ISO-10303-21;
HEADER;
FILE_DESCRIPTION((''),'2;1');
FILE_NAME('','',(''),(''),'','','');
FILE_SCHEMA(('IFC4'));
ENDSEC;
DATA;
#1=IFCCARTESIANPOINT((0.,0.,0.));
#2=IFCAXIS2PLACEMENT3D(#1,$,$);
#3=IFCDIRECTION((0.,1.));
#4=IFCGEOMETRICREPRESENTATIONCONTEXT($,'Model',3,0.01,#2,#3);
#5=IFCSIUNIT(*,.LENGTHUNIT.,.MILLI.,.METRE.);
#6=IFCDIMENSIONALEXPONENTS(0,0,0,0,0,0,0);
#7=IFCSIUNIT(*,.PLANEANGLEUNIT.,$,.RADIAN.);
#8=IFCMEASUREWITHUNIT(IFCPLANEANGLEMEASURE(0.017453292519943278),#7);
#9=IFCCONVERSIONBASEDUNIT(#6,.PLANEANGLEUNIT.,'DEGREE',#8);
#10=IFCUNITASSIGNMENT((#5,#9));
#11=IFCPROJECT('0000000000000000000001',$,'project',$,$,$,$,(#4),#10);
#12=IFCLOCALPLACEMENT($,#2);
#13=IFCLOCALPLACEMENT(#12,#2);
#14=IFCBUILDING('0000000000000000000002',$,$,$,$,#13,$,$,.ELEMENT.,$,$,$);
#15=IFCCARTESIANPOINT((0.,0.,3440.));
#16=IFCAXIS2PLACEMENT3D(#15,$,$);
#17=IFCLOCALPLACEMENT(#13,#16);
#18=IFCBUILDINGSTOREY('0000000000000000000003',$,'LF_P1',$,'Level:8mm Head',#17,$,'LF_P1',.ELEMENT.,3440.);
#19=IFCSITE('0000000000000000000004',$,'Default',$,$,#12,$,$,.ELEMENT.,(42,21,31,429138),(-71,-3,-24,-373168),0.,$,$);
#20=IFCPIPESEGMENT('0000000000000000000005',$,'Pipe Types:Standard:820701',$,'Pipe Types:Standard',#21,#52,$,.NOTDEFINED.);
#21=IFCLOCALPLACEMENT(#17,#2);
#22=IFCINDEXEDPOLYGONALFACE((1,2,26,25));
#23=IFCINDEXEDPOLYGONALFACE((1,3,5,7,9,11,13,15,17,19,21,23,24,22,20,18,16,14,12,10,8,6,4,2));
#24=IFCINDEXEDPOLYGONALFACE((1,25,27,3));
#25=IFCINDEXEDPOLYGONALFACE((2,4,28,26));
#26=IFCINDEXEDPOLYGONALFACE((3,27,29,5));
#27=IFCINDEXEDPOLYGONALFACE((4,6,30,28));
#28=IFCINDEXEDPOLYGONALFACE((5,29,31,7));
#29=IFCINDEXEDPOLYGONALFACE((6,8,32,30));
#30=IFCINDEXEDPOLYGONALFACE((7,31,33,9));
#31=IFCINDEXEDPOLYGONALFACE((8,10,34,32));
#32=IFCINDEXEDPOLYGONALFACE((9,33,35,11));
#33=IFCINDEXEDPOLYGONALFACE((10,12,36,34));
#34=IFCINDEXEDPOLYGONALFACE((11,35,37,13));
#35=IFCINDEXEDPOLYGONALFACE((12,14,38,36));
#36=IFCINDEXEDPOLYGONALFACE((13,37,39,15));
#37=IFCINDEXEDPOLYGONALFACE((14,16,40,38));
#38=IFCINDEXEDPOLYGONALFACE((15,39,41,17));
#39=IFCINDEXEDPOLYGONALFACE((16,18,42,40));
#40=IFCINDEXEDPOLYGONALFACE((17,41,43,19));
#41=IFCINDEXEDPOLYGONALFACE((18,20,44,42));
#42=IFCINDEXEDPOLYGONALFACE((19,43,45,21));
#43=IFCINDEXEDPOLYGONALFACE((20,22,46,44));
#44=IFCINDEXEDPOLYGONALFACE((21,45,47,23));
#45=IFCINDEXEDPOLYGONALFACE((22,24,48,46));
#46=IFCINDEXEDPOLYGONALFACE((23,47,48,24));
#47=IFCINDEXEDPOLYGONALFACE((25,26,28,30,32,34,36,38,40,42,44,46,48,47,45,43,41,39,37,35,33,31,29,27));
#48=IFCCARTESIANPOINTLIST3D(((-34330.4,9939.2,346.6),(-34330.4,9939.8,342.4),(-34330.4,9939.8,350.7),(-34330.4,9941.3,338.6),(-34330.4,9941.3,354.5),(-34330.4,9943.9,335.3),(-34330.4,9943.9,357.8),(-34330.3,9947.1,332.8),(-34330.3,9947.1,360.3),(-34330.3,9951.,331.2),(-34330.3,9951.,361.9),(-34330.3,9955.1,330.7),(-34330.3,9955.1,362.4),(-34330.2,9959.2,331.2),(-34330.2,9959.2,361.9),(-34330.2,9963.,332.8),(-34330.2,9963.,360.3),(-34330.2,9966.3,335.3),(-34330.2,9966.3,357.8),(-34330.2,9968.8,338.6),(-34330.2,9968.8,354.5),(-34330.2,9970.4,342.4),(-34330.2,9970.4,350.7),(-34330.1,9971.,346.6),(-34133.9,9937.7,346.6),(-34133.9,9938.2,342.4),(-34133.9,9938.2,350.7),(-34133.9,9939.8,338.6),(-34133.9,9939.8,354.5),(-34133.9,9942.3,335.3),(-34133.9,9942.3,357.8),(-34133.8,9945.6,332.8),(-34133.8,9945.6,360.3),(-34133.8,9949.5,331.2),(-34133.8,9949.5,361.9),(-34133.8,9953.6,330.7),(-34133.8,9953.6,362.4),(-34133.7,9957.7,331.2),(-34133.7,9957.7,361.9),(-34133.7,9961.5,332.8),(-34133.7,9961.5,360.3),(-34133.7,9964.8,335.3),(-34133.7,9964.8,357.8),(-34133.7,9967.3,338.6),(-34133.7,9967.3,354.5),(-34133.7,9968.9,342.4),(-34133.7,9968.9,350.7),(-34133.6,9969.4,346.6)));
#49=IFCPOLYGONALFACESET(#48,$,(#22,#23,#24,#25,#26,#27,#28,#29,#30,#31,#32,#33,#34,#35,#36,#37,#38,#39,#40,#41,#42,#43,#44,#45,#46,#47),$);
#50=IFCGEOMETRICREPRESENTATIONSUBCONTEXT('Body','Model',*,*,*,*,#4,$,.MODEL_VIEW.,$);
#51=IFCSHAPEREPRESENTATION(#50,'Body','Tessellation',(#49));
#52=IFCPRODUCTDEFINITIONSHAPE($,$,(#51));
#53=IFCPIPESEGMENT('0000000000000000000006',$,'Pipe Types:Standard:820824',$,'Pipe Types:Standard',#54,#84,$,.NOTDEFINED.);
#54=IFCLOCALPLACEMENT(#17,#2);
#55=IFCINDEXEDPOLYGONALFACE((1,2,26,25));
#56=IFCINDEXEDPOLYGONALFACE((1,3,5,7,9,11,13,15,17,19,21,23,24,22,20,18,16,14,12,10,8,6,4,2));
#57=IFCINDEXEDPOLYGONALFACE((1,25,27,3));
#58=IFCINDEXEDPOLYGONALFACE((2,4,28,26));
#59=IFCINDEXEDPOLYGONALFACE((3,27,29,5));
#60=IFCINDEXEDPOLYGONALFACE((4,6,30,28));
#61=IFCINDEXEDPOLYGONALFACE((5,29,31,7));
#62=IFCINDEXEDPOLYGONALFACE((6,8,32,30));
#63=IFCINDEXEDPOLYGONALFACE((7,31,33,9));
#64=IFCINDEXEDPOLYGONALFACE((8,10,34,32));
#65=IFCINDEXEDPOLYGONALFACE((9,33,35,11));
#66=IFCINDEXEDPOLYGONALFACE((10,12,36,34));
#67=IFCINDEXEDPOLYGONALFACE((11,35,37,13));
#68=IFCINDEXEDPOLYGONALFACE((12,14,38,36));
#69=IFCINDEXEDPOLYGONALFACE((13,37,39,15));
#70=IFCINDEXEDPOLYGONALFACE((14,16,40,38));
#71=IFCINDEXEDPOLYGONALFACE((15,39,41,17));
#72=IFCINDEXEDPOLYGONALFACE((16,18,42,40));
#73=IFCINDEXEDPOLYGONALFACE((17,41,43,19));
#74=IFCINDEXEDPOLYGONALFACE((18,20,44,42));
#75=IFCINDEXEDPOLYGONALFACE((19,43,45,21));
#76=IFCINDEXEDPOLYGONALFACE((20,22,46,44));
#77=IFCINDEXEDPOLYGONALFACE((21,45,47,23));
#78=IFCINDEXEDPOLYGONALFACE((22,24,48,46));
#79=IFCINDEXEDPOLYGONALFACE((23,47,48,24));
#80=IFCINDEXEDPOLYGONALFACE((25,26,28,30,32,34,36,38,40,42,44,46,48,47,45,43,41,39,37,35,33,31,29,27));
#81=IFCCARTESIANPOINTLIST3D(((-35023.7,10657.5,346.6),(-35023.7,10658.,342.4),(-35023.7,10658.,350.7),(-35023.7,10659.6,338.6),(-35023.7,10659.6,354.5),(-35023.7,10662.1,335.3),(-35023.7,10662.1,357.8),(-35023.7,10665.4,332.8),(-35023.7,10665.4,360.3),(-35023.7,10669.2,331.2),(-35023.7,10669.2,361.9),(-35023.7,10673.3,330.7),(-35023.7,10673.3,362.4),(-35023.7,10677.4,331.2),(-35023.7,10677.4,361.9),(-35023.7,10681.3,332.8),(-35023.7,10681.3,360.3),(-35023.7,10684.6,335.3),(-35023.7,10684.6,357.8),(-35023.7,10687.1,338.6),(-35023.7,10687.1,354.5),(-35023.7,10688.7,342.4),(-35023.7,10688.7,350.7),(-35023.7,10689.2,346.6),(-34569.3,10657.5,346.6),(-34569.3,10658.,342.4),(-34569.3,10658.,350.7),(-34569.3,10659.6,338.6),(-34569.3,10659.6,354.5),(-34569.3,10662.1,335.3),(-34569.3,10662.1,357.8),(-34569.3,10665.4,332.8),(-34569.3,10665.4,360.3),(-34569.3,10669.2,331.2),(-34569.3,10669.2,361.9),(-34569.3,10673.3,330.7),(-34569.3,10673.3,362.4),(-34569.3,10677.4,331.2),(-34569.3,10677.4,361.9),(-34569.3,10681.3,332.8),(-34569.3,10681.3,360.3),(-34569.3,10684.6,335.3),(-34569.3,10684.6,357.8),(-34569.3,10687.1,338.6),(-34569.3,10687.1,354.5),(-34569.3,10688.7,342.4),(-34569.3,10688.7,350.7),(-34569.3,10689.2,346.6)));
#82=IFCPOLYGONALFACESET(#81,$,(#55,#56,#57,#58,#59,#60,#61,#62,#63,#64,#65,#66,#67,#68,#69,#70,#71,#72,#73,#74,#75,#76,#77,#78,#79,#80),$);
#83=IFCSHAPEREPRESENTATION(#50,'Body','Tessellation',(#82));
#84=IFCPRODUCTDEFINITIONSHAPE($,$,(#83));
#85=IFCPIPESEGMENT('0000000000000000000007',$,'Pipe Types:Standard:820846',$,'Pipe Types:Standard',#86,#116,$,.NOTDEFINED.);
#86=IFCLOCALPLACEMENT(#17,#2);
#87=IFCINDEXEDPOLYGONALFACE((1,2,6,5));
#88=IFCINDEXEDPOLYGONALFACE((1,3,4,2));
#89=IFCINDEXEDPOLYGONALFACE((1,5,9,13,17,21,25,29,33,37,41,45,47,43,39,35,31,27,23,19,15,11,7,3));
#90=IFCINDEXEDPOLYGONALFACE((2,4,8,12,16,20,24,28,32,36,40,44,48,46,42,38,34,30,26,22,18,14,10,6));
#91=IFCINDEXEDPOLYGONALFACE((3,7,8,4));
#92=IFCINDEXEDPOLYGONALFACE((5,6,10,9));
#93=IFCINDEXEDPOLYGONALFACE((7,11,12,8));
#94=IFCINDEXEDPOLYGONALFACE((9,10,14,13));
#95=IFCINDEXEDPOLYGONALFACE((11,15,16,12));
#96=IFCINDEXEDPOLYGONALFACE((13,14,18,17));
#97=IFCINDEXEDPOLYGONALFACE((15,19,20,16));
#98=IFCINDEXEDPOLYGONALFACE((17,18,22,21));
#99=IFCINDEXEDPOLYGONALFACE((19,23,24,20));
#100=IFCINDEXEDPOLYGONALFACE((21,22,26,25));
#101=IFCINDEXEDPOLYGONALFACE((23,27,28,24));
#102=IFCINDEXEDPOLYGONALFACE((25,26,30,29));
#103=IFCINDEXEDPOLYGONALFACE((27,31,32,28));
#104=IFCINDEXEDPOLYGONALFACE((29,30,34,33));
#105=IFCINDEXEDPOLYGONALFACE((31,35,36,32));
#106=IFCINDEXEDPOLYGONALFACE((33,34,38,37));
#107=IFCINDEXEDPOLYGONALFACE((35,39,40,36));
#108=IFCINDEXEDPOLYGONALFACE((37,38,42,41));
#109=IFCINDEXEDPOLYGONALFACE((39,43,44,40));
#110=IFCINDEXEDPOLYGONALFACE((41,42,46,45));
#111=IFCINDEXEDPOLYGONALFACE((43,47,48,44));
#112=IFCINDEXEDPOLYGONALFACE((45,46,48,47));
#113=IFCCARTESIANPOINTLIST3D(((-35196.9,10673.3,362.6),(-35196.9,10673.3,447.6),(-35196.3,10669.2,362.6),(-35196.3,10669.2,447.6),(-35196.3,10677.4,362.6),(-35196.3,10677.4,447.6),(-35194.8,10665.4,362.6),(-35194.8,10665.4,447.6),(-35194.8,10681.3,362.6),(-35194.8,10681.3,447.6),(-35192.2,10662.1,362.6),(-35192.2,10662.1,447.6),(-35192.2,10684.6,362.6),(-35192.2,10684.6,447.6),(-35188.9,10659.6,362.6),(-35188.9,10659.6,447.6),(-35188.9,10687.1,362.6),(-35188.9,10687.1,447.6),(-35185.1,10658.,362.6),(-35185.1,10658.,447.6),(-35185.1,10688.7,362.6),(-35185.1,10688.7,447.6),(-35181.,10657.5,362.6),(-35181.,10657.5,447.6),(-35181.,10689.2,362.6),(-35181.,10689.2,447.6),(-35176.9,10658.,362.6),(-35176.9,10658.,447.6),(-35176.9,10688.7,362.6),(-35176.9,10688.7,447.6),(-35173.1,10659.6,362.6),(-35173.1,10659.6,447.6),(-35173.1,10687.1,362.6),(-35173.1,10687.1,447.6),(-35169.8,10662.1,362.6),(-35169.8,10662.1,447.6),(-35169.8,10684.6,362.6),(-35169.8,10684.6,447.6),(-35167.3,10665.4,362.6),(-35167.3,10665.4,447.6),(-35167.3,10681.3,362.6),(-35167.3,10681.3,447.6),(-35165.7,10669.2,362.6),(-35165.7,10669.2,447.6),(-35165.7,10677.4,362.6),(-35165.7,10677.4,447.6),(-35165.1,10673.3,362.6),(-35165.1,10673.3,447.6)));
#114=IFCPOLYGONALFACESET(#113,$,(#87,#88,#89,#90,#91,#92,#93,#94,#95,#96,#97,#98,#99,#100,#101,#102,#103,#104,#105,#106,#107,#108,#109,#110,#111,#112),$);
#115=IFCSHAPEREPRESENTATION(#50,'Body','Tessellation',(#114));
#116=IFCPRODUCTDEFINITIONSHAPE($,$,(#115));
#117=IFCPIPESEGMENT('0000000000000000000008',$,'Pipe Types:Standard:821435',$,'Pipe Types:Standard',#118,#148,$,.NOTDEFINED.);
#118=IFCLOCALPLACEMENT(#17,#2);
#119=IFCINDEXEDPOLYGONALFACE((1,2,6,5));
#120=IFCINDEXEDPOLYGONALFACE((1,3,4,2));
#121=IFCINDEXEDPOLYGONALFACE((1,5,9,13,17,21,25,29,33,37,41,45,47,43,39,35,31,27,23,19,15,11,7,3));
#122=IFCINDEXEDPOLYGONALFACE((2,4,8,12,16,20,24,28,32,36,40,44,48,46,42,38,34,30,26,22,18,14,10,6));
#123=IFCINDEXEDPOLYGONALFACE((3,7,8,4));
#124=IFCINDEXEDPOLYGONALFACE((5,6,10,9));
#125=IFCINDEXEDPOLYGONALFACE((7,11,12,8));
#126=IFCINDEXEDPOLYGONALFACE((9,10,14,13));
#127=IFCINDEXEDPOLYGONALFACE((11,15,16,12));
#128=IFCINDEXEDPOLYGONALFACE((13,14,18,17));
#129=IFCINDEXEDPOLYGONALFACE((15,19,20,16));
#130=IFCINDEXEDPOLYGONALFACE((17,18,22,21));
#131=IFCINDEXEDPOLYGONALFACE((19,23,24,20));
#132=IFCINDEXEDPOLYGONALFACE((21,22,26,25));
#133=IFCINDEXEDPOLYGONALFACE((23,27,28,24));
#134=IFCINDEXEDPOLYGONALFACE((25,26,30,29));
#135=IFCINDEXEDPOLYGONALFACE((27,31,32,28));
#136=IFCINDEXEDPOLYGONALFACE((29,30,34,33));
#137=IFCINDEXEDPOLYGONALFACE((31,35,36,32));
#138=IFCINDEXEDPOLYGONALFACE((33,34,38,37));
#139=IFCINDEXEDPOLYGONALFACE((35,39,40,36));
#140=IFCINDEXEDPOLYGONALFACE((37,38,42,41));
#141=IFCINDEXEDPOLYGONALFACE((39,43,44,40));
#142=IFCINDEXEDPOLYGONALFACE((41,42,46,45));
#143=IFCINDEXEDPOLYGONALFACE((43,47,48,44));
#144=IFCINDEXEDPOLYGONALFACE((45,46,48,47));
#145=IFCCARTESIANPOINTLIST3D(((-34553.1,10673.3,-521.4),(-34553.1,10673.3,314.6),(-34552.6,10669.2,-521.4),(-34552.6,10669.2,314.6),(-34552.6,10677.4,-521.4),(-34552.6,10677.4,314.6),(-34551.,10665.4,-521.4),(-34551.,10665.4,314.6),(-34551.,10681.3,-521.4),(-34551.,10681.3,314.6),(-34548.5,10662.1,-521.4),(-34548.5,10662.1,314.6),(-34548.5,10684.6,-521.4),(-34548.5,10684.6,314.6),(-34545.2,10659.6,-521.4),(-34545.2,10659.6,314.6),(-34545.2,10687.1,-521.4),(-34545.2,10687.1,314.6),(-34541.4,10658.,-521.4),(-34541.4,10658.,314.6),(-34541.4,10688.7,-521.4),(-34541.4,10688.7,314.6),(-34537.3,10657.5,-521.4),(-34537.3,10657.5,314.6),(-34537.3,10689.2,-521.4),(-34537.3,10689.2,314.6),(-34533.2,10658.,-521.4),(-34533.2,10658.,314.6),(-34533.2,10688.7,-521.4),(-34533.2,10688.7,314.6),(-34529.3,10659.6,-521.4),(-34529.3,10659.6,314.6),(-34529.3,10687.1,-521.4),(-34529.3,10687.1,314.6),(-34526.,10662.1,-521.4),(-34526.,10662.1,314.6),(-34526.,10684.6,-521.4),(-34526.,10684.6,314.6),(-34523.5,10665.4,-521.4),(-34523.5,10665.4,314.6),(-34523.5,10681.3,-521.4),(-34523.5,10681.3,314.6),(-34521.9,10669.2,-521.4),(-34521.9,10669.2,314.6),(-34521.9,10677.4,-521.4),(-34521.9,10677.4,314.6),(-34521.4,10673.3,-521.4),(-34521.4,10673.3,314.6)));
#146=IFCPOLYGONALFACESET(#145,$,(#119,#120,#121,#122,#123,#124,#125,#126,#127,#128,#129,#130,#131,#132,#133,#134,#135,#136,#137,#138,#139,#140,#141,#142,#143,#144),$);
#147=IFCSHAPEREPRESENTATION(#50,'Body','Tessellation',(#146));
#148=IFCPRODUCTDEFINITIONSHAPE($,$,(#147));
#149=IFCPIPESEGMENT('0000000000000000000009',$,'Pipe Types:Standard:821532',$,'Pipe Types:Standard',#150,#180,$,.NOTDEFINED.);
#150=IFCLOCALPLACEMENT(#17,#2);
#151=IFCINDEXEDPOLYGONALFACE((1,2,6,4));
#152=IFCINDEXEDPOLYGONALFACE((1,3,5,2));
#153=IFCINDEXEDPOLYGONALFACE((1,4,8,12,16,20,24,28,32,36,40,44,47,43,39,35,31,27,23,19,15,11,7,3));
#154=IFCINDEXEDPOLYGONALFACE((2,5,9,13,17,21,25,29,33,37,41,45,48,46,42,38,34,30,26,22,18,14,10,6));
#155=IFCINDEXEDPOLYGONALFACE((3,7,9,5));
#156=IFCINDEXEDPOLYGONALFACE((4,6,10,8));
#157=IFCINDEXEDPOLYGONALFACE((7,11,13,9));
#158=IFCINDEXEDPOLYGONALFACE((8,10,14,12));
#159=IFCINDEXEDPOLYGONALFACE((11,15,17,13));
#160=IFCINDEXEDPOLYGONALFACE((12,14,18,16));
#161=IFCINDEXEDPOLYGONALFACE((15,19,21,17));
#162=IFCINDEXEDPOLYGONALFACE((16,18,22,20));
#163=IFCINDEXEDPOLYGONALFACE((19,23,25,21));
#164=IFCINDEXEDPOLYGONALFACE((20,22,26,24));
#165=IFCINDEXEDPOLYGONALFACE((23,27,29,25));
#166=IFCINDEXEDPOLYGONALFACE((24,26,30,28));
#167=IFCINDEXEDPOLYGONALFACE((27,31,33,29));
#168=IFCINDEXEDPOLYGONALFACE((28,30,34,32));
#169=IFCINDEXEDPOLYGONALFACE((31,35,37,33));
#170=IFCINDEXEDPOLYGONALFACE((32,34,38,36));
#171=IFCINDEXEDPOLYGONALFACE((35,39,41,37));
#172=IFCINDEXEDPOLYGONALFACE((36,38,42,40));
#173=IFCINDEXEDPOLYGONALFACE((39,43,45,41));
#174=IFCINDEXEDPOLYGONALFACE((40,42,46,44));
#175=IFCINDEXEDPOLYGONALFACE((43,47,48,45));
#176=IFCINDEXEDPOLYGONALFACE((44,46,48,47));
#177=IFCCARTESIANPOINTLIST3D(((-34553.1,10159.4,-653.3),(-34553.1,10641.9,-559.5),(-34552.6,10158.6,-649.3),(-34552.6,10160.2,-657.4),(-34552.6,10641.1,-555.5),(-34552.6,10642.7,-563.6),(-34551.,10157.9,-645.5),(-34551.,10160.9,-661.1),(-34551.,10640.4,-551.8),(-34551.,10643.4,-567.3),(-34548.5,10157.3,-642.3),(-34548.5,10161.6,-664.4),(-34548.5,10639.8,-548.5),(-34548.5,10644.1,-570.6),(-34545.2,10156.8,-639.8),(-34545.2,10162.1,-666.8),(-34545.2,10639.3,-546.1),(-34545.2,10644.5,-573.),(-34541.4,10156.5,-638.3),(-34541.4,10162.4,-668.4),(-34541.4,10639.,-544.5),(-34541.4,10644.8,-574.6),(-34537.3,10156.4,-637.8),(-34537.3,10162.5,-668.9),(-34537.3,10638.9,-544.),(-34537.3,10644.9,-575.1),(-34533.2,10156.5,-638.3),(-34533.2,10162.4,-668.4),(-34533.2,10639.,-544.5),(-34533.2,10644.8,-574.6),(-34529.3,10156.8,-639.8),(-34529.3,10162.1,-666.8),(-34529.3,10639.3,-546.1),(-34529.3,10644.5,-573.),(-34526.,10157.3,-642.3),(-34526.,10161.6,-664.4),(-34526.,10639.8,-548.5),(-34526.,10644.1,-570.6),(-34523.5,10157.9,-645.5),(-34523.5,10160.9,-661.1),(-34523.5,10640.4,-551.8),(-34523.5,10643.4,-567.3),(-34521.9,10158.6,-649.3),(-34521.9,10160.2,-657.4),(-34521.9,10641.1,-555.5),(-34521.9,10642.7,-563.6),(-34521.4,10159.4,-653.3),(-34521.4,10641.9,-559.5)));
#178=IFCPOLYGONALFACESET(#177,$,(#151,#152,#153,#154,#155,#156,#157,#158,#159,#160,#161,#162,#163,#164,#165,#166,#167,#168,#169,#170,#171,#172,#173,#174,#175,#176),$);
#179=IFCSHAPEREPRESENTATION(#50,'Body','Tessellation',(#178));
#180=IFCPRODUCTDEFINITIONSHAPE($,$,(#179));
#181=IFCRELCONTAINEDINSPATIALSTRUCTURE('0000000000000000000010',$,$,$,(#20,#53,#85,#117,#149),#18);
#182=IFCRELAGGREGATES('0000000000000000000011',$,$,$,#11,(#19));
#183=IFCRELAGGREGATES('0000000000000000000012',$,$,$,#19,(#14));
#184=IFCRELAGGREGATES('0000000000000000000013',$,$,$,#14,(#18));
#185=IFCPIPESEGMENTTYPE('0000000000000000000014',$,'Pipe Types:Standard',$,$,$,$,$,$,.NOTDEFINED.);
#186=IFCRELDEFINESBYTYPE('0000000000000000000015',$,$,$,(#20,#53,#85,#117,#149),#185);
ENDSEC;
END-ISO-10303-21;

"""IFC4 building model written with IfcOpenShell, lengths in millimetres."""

from ifc_helpers import new_model, entity, si_unit, converted_unit, direction, frame, origin, place, context, subcontext, project, spatial, arc, indexed_curve, outline, extrude, type_object, element, save


model = new_model("IFC4")

# Units and contexts
model_context = context("Model", 3, precision=0.01, world=origin(), true_north=direction((0.0, 1.0)))
body_context = subcontext(model_context, "Body", "Model", "MODEL_VIEW")
ifc_project = project(units=[si_unit("LENGTHUNIT", "METRE", prefix="MILLI"), converted_unit("PLANEANGLEUNIT", "DEGREE", entity("IfcPlaneAngleMeasure", 0.017453292519943278), si_unit("PLANEANGLEUNIT", "RADIAN"), dimensions=[0, 0, 0, 0, 0, 0, 0])], contexts=[model_context])

# Site, building, storey
site_placement = place(None, origin())
site = spatial("IfcSite", under=ifc_project, at=site_placement, Name="Default", CompositionType="ELEMENT", RefLatitude=(42, 21, 31, 429138), RefLongitude=(-71, -3, -24, -373168), RefElevation=0.0)
building_placement = place(site_placement, origin())
building = spatial("IfcBuilding", under=site, at=building_placement, CompositionType="ELEMENT")
storey_placement = place(building_placement, frame((0.0, 0.0, 3440.0)))
storey = spatial("IfcBuildingStorey", under=building, at=storey_placement, Name="LF_P1", ObjectType="Level:8mm Head", LongName="LF_P1", CompositionType="ELEMENT", Elevation=3440.0)

# Pipe segments
pipe_segment_type_1 = type_object("IfcPipeSegmentType", Name="Pipe Types:Standard", PredefinedType="NOTDEFINED")
pipe_segment_1_placement = place(storey_placement, origin())
element("IfcPipeSegment", 1, at=pipe_segment_1_placement, inside=storey, type_object=pipe_segment_type_1, Name="Pipe Types:Standard:820701", ObjectType="Pipe Types:Standard", PredefinedType="NOTDEFINED", context=body_context, shape_type="SweptSolid", body=[
    extrude(outline(indexed_curve([(15.9, 0.0), (11.2, 11.2), (0.0, 15.9), (-11.2, 11.2), (-15.9, 0.0), (-11.2, -11.2), (0.0, -15.9), (11.2, -11.2)], segments=[arc(1, 2, 3), arc(3, 4, 5), arc(5, 6, 7), arc(7, 8, 1)], self_intersect=False)), frame((-34330.3, 9955.1, 346.6), z_axis=(0.999971, -0.00768, 0.0), x_axis=(0.00768, 0.999971, 0.0)), (0.0, 0.0, 1.0), 196.5),
])
pipe_segment_2_placement = place(storey_placement, origin())
element("IfcPipeSegment", 2, at=pipe_segment_2_placement, inside=storey, type_object=pipe_segment_type_1, Name="Pipe Types:Standard:820824", ObjectType="Pipe Types:Standard", PredefinedType="NOTDEFINED", context=body_context, shape_type="SweptSolid", body=[
    extrude(outline(indexed_curve([(15.9, 0.0), (11.2, 11.2), (0.0, 15.9), (-11.2, 11.2), (-15.9, 0.0), (-11.2, -11.2), (0.0, -15.9), (11.2, -11.2)], segments=[arc(1, 2, 3), arc(3, 4, 5), arc(5, 6, 7), arc(7, 8, 1)], self_intersect=False)), frame((-35023.7, 10673.3, 346.6), z_axis=(1.0, 0.0, 0.0), x_axis=(0.0, 1.0, 0.0)), (0.0, 0.0, 1.0), 454.4),
])
pipe_segment_3_placement = place(storey_placement, origin())
element("IfcPipeSegment", 3, at=pipe_segment_3_placement, inside=storey, type_object=pipe_segment_type_1, Name="Pipe Types:Standard:820846", ObjectType="Pipe Types:Standard", PredefinedType="NOTDEFINED", context=body_context, shape_type="SweptSolid", body=[
    extrude(outline(indexed_curve([(15.9, 0.0), (11.2, 11.2), (0.0, 15.9), (-11.2, 11.2), (-15.9, 0.0), (-11.2, -11.2), (0.0, -15.9), (11.2, -11.2)], segments=[arc(1, 2, 3), arc(3, 4, 5), arc(5, 6, 7), arc(7, 8, 1)], self_intersect=False)), frame((-35181.0, 10673.3, 362.6)), (0.0, 0.0, 1.0), 85.0),
])
pipe_segment_4_placement = place(storey_placement, origin())
element("IfcPipeSegment", 4, at=pipe_segment_4_placement, inside=storey, type_object=pipe_segment_type_1, Name="Pipe Types:Standard:821435", ObjectType="Pipe Types:Standard", PredefinedType="NOTDEFINED", context=body_context, shape_type="SweptSolid", body=[
    extrude(outline(indexed_curve([(15.9, 0.0), (11.2, 11.2), (0.0, 15.9), (-11.2, 11.2), (-15.9, 0.0), (-11.2, -11.2), (0.0, -15.9), (11.2, -11.2)], segments=[arc(1, 2, 3), arc(3, 4, 5), arc(5, 6, 7), arc(7, 8, 1)], self_intersect=False)), frame((-34537.3, 10673.3, -521.4)), (0.0, 0.0, 1.0), 836.0),
])
pipe_segment_5_placement = place(storey_placement, origin())
element("IfcPipeSegment", 5, at=pipe_segment_5_placement, inside=storey, type_object=pipe_segment_type_1, Name="Pipe Types:Standard:821532", ObjectType="Pipe Types:Standard", PredefinedType="NOTDEFINED", context=body_context, shape_type="SweptSolid", body=[
    extrude(outline(indexed_curve([(15.9, 0.0), (11.2, 11.2), (0.0, 15.9), (-11.2, 11.2), (-15.9, 0.0), (-11.2, -11.2), (0.0, -15.9), (11.2, -11.2)], segments=[arc(1, 2, 3), arc(3, 4, 5), arc(5, 6, 7), arc(7, 8, 1)], self_intersect=False)), frame((-34537.3, 10159.4, -653.3), z_axis=(0.0, 0.981627, 0.190809), x_axis=(1.0, 0.0, 0.0)), (0.0, 0.0, 1.0), 491.5),
])

save(model, "model.ifc")
